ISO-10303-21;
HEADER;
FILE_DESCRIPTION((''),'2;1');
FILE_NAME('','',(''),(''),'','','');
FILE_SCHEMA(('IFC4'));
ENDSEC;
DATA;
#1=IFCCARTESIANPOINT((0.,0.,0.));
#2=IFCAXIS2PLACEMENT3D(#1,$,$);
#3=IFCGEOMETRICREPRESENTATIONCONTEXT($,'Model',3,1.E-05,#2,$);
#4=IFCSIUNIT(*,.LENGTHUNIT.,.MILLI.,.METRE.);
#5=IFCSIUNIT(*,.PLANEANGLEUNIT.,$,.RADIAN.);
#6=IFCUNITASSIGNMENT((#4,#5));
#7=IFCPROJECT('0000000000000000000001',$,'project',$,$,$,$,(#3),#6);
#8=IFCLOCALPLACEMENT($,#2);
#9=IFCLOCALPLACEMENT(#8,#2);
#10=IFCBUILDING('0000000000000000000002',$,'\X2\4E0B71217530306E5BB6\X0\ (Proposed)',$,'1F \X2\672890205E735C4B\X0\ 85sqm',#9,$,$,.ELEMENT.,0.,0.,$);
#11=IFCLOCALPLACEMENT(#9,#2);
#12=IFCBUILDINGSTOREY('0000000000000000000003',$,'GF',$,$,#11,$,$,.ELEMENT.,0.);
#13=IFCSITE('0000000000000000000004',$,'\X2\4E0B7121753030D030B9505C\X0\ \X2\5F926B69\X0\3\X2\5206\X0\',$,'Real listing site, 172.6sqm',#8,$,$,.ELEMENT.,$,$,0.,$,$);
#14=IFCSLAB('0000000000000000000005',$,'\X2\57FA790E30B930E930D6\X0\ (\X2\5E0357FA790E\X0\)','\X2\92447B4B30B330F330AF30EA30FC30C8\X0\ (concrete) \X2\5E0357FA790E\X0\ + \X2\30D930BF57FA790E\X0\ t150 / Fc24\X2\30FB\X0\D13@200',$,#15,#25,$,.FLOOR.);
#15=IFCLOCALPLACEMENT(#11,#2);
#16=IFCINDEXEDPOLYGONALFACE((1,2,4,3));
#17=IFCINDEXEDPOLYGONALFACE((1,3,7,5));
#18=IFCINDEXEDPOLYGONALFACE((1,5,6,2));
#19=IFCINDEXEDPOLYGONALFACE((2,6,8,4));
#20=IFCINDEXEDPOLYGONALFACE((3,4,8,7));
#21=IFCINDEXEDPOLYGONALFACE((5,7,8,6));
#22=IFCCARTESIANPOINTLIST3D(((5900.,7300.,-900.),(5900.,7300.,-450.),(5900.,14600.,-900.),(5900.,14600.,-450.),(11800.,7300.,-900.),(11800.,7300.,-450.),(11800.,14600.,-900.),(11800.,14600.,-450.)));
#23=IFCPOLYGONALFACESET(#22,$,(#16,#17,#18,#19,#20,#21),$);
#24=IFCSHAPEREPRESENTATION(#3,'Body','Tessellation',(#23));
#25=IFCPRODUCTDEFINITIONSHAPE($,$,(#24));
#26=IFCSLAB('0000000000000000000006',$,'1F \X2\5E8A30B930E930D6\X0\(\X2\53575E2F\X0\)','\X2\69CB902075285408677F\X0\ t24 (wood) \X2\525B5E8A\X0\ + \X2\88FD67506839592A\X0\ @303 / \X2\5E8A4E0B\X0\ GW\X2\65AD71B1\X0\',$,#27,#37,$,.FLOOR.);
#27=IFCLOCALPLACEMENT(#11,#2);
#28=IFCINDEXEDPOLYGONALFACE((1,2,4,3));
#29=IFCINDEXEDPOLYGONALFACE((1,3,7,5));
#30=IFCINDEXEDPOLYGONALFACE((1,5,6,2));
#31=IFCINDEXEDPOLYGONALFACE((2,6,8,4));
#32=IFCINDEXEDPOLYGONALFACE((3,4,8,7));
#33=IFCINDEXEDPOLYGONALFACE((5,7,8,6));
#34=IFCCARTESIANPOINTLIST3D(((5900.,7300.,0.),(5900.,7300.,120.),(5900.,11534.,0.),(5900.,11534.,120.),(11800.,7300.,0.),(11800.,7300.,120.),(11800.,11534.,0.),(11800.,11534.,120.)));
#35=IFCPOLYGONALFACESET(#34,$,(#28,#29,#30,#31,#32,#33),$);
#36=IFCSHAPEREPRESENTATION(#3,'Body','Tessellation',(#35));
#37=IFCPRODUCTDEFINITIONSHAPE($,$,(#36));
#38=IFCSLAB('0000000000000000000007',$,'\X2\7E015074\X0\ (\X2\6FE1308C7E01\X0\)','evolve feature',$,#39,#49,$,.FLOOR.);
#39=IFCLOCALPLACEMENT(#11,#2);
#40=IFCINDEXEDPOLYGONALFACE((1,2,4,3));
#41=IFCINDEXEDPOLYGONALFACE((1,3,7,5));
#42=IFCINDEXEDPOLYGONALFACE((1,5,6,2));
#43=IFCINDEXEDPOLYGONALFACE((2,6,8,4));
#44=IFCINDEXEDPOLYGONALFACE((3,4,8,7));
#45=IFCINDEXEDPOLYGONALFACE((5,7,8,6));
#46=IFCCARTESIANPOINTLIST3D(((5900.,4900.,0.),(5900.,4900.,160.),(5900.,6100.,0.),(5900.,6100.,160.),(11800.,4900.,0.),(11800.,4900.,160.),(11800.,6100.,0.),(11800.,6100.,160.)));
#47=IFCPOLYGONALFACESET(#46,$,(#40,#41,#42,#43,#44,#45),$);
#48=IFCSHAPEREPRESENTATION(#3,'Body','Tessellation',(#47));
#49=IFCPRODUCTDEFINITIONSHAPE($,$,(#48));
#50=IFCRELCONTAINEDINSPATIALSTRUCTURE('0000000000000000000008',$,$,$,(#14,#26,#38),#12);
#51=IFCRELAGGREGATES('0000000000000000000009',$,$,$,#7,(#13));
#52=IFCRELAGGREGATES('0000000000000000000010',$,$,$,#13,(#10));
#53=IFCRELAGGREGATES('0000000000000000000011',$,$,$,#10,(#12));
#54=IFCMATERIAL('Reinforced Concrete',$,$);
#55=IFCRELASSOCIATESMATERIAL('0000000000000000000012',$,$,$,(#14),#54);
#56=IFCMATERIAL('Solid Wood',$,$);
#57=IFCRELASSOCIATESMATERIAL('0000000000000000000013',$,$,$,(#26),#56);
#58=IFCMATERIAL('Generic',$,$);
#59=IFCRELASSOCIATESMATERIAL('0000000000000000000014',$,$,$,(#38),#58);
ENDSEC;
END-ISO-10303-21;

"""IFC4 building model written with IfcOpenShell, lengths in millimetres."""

from ifc_helpers import new_model, si_unit, frame, frame_2d, origin, place, context, project, spatial, rectangle, extrude, material, element, save


model = new_model("IFC4")

# Units and contexts
model_context = context("Model", 3, precision=1e-05, world=origin())
ifc_project = project(units=[si_unit("LENGTHUNIT", "METRE", prefix="MILLI"), si_unit("PLANEANGLEUNIT", "RADIAN")], contexts=[model_context])

# Site, building, storey
site_placement = place(None, origin())
site = spatial("IfcSite", under=ifc_project, at=site_placement, Name="下無田バス停 徒歩3分", ObjectType="Real listing site, 172.6sqm", CompositionType="ELEMENT", RefElevation=0.0)
building_placement = place(site_placement, origin())
building = spatial("IfcBuilding", under=site, at=building_placement, Name="下無田の家 (Proposed)", ObjectType="1F 木造平屋 85sqm", CompositionType="ELEMENT", ElevationOfRefHeight=0.0, ElevationOfTerrain=0.0)
storey_placement = place(building_placement, origin())
storey = spatial("IfcBuildingStorey", under=building, at=storey_placement, Name="GF", CompositionType="ELEMENT", Elevation=0.0)

# Slabs
ifc_material_1 = material(Name="Reinforced Concrete")
slab_1_placement = place(storey_placement, frame((2950.0, 3650.0, -450.0)))
element("IfcSlab", 1, at=slab_1_placement, inside=storey, material=ifc_material_1, Name="基礎スラブ (布基礎)", Description="鉄筋コンクリート (concrete) 布基礎 + ベタ基礎 t150 / Fc24・D13@200", PredefinedType="FLOOR", context=model_context, shape_type="SweptSolid", body=[
    extrude(rectangle(XDim=5900.0, YDim=7300.0, at=frame_2d((2950.0, 3650.0))), frame((2950.0, 3650.0, -450.0)), (0.0, 0.0, 1.0), 450.0),
])
ifc_material_2 = material(Name="Solid Wood")
slab_2_placement = place(storey_placement, frame((2950.0, 3650.0, 0.0)))
element("IfcSlab", 2, at=slab_2_placement, inside=storey, material=ifc_material_2, Name="1F 床スラブ(南帯)", Description="構造用合板 t24 (wood) 剛床 + 製材根太 @303 / 床下 GW断熱", PredefinedType="FLOOR", context=model_context, shape_type="SweptSolid", body=[
    extrude(rectangle(XDim=5900.0, YDim=4234.0, at=frame_2d((2950.0, 2117.0))), frame((2950.0, 3650.0, 0.0)), (0.0, 0.0, 1.0), 120.0),
])
ifc_material_3 = material(Name="Generic")
slab_3_placement = place(storey_placement, frame((2950.0, 2450.0, 0.0)))
element("IfcSlab", 3, at=slab_3_placement, inside=storey, material=ifc_material_3, Name="縁側 (濡れ縁)", Description="evolve feature", PredefinedType="FLOOR", context=model_context, shape_type="SweptSolid", body=[
    extrude(rectangle(XDim=5900.0, YDim=1200.0, at=frame_2d((2950.0, 600.0))), frame((2950.0, 2450.0, 0.0)), (0.0, 0.0, 1.0), 160.0),
])

save(model, "model.ifc")
